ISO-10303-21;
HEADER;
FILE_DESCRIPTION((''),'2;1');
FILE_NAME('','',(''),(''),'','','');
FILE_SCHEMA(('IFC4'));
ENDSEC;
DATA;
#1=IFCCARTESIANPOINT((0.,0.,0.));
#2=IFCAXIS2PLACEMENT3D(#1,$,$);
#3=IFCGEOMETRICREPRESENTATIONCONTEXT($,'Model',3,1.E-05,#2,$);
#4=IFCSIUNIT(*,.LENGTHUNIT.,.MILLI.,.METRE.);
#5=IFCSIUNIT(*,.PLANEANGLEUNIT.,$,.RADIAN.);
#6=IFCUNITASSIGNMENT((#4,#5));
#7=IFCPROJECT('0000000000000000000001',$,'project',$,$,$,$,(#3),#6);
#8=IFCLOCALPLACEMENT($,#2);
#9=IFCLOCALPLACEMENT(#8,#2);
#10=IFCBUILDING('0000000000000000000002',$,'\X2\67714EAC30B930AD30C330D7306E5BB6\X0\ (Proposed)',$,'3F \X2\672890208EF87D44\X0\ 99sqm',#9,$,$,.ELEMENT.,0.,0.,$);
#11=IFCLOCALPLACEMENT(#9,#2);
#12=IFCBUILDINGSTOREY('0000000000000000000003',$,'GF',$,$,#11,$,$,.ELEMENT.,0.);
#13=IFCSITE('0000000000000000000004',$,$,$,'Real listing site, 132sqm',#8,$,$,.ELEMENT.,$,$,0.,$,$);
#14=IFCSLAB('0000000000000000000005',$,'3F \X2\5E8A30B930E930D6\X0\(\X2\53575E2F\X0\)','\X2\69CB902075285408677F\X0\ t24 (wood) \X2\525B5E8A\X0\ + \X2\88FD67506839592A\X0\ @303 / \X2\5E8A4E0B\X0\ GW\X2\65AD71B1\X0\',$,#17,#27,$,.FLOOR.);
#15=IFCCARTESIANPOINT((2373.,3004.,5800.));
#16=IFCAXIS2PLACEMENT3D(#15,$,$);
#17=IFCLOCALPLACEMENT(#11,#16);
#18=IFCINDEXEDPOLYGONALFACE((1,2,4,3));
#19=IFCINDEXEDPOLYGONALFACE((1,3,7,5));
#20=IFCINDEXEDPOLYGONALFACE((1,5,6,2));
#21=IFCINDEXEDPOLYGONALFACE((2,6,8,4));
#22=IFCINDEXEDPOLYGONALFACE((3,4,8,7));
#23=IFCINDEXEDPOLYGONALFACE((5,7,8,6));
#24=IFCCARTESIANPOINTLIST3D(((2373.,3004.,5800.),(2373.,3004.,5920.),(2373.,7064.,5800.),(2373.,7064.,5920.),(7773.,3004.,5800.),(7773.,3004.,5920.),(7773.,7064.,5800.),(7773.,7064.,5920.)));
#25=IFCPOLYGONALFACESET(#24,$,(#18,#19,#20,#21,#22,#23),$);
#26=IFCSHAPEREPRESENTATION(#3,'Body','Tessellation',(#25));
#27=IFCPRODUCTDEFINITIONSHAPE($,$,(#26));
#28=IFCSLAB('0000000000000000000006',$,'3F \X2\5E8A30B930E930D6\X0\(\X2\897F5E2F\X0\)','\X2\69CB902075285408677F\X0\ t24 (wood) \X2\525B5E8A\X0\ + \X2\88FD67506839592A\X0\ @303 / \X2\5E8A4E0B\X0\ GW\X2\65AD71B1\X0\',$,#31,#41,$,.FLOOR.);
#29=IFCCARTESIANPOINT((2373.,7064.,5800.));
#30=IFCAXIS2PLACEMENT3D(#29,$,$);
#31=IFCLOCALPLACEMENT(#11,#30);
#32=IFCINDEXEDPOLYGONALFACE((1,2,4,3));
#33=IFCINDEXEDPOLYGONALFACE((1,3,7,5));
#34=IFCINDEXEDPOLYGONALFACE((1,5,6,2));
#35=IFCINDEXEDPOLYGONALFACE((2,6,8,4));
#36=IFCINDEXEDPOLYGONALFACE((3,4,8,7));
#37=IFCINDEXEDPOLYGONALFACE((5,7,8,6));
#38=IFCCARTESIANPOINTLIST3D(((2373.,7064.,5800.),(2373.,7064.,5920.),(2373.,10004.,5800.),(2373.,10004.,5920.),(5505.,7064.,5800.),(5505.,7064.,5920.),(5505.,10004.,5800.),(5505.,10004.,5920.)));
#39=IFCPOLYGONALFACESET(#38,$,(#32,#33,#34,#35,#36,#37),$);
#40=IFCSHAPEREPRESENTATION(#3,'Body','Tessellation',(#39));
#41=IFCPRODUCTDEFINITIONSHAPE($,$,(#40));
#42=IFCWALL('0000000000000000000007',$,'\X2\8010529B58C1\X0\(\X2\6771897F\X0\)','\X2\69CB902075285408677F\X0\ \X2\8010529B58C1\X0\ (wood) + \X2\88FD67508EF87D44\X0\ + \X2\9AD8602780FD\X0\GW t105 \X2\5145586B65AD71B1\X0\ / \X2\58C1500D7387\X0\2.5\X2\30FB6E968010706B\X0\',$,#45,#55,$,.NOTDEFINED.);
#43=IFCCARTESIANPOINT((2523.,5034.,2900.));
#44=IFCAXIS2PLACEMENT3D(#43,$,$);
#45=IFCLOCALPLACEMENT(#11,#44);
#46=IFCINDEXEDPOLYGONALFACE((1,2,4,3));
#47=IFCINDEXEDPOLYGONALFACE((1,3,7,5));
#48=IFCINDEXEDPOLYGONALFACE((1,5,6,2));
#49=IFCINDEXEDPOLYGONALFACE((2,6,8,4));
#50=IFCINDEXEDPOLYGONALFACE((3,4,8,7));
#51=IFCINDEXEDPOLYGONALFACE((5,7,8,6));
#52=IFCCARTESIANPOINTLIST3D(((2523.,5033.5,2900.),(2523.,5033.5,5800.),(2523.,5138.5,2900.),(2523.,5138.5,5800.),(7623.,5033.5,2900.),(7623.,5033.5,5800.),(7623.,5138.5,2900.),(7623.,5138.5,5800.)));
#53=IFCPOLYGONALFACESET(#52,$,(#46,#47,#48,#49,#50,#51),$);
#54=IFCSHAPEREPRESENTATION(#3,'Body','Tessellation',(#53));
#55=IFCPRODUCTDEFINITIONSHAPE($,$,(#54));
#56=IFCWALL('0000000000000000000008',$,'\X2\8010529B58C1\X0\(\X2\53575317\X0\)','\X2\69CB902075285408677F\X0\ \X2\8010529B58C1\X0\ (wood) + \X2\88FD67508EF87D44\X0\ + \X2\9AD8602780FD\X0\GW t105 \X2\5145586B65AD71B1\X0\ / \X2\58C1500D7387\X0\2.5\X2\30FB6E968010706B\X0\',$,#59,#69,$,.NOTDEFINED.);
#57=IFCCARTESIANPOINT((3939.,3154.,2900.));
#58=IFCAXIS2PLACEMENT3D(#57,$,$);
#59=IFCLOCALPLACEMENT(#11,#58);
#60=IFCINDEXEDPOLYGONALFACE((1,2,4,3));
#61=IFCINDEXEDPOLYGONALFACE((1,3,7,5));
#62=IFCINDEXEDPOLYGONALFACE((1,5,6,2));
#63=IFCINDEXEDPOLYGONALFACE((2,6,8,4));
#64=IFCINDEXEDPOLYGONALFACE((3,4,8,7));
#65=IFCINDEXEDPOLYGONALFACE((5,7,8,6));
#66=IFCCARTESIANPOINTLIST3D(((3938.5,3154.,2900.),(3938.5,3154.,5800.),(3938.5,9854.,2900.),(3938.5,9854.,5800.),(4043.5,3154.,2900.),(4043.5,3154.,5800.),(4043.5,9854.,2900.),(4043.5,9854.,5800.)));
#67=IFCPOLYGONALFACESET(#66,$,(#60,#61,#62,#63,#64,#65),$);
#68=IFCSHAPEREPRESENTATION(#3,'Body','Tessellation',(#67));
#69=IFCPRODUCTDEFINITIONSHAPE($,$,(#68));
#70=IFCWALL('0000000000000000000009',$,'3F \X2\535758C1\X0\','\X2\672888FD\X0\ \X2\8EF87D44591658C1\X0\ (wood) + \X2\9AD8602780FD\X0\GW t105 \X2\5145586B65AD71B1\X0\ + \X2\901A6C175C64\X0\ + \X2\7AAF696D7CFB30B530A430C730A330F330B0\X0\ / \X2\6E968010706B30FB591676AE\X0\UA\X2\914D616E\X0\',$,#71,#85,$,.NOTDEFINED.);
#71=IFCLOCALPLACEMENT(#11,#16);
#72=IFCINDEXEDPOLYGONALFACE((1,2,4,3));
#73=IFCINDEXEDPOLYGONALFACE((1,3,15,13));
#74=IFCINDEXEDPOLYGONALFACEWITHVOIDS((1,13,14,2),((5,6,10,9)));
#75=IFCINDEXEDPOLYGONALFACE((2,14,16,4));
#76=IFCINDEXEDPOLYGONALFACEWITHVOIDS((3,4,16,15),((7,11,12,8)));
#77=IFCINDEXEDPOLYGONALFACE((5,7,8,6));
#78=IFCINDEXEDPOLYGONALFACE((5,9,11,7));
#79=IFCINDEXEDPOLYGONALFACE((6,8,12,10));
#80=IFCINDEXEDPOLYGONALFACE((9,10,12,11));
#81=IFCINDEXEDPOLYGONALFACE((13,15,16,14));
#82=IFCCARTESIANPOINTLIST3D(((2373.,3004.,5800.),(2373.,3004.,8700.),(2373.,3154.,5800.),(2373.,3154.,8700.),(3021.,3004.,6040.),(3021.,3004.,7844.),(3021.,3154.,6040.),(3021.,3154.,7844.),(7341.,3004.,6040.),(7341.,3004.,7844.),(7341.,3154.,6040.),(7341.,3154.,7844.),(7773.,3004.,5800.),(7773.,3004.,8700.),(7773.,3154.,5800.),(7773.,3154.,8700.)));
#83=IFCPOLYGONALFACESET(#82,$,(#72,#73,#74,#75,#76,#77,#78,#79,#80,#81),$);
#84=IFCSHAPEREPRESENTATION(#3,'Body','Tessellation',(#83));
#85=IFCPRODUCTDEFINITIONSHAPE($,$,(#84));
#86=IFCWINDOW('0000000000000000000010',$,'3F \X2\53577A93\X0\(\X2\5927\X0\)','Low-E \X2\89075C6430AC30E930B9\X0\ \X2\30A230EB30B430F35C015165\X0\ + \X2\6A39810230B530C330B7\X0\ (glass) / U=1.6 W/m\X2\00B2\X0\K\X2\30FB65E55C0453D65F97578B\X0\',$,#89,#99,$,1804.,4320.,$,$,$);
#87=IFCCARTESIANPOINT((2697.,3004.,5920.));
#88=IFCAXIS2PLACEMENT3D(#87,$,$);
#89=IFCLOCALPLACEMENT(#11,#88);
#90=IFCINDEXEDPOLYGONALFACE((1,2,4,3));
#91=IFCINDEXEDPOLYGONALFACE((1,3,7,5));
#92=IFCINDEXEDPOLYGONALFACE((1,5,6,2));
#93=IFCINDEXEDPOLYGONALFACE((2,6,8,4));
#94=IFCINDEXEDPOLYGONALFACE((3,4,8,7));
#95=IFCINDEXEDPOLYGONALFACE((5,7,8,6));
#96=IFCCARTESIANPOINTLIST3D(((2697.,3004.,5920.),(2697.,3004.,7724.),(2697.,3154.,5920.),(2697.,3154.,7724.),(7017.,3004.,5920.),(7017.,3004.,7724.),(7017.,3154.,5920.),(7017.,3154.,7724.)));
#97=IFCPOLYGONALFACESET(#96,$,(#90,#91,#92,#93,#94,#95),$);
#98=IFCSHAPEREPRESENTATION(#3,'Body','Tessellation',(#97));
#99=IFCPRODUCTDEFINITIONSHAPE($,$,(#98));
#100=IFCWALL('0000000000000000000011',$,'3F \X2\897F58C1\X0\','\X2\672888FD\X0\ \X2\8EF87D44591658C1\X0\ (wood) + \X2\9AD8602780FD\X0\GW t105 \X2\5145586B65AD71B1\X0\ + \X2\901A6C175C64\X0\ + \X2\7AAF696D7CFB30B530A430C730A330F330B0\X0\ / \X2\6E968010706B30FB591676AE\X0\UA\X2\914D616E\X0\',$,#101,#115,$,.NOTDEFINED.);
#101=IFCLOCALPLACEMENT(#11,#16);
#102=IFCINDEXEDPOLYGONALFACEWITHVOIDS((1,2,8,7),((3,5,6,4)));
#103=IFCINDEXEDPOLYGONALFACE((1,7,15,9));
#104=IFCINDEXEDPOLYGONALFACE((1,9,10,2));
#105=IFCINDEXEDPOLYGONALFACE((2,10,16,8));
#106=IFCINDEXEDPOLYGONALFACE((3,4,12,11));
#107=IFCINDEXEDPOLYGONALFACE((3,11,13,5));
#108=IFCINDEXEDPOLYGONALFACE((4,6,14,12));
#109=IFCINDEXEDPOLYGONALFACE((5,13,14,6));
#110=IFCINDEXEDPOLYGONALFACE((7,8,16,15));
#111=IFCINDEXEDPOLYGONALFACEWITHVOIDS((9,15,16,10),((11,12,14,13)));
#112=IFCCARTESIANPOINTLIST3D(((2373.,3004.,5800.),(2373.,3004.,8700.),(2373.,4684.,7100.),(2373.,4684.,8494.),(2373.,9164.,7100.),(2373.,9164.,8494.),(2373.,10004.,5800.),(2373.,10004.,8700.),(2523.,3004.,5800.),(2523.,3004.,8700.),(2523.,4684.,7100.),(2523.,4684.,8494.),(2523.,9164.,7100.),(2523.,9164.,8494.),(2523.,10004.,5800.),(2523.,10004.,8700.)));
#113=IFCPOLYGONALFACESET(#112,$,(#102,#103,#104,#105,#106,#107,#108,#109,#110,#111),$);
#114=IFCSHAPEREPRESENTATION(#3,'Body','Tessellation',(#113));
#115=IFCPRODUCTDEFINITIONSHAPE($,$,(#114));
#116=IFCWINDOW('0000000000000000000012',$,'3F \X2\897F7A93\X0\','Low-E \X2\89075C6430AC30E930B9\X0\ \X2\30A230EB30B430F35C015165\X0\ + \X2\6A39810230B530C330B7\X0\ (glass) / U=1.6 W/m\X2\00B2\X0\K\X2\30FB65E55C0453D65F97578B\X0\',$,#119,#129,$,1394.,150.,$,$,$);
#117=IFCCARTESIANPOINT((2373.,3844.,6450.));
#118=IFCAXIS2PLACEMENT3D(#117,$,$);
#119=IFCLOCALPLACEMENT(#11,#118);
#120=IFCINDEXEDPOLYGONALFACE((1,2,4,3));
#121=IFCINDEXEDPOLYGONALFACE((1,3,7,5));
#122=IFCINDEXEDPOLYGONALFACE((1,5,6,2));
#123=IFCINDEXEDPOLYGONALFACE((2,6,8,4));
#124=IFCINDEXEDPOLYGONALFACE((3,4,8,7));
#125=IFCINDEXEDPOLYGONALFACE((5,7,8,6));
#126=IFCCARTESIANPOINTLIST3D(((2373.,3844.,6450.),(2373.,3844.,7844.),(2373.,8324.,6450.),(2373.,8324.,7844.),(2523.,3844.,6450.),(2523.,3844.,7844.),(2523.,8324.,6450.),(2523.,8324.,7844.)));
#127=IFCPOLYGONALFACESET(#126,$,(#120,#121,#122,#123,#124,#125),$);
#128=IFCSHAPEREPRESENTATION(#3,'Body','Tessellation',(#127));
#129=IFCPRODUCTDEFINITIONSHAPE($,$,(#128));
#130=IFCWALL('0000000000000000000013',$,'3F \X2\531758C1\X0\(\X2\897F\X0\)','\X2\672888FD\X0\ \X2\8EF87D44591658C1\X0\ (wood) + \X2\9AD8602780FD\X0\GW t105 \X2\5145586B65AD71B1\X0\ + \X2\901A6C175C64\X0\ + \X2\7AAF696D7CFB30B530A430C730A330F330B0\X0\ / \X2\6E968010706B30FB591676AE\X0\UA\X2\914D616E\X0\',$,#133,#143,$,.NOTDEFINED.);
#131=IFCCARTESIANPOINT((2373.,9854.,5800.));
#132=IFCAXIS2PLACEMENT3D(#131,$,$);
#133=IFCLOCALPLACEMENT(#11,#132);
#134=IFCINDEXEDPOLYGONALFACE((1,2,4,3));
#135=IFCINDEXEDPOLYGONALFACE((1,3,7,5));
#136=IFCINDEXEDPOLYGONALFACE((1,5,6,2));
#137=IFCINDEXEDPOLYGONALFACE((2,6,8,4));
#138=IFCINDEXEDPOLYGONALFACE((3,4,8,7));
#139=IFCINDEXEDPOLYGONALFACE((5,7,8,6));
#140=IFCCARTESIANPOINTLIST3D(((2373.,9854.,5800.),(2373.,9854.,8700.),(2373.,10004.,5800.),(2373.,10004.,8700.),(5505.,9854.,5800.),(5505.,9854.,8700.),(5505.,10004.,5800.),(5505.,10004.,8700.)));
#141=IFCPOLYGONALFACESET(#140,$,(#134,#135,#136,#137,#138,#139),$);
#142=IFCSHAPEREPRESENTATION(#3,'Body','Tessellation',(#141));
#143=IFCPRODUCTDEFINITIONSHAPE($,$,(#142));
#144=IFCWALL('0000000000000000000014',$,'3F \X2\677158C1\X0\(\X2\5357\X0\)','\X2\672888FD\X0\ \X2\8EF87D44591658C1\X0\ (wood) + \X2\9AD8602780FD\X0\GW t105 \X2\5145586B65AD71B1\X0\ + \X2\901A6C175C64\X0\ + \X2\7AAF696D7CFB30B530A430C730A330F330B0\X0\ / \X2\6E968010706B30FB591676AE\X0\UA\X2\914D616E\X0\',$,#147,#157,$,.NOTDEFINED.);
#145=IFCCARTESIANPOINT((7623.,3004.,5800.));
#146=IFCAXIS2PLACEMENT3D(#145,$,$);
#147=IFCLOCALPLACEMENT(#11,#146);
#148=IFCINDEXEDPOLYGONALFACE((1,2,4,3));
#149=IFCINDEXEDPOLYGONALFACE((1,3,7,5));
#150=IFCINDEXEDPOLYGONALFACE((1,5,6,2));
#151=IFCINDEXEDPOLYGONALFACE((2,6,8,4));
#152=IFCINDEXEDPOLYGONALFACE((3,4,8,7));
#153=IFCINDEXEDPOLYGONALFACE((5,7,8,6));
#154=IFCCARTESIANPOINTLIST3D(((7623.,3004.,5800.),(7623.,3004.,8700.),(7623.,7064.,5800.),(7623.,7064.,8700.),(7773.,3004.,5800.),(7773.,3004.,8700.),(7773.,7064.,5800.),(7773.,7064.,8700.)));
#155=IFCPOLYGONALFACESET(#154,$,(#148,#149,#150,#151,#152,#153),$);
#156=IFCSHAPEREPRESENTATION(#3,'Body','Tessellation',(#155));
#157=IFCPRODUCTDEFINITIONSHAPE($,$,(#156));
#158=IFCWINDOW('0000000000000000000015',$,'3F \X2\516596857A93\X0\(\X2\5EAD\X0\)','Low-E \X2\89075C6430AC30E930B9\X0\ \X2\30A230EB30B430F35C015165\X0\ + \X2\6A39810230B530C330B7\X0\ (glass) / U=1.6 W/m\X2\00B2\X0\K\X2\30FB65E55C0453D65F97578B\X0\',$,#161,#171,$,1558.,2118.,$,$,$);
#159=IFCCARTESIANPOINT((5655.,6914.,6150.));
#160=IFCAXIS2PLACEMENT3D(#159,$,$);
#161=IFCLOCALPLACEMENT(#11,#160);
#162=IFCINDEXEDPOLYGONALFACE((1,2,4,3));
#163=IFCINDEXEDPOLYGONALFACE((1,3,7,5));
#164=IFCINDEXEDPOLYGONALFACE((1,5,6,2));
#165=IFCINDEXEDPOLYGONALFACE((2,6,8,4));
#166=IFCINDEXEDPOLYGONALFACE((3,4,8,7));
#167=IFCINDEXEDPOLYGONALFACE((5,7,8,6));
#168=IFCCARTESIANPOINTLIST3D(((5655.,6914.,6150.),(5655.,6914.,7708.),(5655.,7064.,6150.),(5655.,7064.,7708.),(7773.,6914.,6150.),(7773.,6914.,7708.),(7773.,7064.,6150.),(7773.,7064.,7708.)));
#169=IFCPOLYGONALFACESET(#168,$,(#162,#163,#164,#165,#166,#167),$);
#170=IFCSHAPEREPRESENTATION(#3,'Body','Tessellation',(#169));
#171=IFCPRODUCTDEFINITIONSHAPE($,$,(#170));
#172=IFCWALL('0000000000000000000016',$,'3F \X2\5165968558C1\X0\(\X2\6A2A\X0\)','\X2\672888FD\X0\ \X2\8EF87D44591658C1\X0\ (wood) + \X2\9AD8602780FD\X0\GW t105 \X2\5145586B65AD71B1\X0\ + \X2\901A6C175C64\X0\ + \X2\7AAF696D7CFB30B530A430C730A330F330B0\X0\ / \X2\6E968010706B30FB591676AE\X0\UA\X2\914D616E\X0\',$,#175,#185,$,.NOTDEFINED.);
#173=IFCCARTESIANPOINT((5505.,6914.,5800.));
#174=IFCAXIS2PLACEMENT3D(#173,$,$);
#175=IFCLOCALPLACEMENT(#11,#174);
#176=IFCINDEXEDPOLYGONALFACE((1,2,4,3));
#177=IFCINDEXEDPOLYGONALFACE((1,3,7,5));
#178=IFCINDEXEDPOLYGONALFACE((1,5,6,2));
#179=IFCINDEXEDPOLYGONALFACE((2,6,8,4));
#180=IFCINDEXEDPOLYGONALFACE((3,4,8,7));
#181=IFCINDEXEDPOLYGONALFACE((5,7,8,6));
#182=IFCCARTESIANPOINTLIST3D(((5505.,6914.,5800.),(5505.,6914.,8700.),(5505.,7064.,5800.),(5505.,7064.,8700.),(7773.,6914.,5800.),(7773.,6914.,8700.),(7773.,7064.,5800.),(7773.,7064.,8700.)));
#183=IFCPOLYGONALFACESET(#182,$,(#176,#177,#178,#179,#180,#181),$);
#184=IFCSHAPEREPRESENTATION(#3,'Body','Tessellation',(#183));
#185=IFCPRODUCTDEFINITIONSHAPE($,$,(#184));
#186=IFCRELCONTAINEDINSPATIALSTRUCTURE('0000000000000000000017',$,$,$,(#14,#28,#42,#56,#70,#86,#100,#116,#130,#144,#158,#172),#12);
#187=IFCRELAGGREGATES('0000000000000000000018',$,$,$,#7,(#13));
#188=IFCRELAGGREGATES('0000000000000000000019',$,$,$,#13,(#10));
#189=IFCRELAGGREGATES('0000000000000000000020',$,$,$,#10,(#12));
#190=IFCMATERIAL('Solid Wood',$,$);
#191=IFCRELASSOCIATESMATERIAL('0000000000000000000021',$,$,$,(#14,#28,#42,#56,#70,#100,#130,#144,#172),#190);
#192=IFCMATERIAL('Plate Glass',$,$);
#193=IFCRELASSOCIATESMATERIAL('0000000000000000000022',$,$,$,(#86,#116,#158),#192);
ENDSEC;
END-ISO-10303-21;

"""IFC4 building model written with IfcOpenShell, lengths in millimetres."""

from ifc_helpers import new_model, si_unit, frame, frame_2d, origin, place, context, project, spatial, rectangle, extrude, material, element, fill, save


model = new_model("IFC4")

# Units and contexts
model_context = context("Model", 3, precision=1e-05, world=origin())
ifc_project = project(units=[si_unit("LENGTHUNIT", "METRE", prefix="MILLI"), si_unit("PLANEANGLEUNIT", "RADIAN")], contexts=[model_context])

# Site, building, storey
site_placement = place(None, origin())
site = spatial("IfcSite", under=ifc_project, at=site_placement, ObjectType="Real listing site, 132sqm", CompositionType="ELEMENT", RefElevation=0.0)
building_placement = place(site_placement, origin())
building = spatial("IfcBuilding", under=site, at=building_placement, Name="東京スキップの家 (Proposed)", ObjectType="3F 木造軸組 99sqm", CompositionType="ELEMENT", ElevationOfRefHeight=0.0, ElevationOfTerrain=0.0)
storey_placement = place(building_placement, origin())
storey = spatial("IfcBuildingStorey", under=building, at=storey_placement, Name="GF", CompositionType="ELEMENT", Elevation=0.0)

# Slabs
ifc_material_1 = material(Name="Solid Wood")
slab_1_placement = place(storey_placement, frame((2373.0, 3004.0, 5800.0)))
element("IfcSlab", 1, at=slab_1_placement, inside=storey, material=ifc_material_1, Name="3F 床スラブ(南帯)", Description="構造用合板 t24 (wood) 剛床 + 製材根太 @303 / 床下 GW断熱", PredefinedType="FLOOR", context=model_context, shape_type="SweptSolid", body=[
    extrude(rectangle(XDim=5400.0, YDim=4060.0, at=frame_2d((2700.0, 2030.0))), frame((2373.0, 3004.0, 5800.0)), (0.0, 0.0, 1.0), 120.0),
])
slab_2_placement = place(storey_placement, frame((2373.0, 7064.0, 5800.0)))
element("IfcSlab", 2, at=slab_2_placement, inside=storey, material=ifc_material_1, Name="3F 床スラブ(西帯)", Description="構造用合板 t24 (wood) 剛床 + 製材根太 @303 / 床下 GW断熱", PredefinedType="FLOOR", context=model_context, shape_type="SweptSolid", body=[
    extrude(rectangle(XDim=3132.0, YDim=2940.0, at=frame_2d((1566.0, 1470.0))), frame((2373.0, 7064.0, 5800.0)), (0.0, 0.0, 1.0), 120.0),
])

# Walls
wall_1_placement = place(storey_placement, frame((2523.0, 5034.0, 2900.0)))
element("IfcWall", 3, at=wall_1_placement, inside=storey, material=ifc_material_1, Name="耐力壁(東西)", Description="構造用合板 耐力壁 (wood) + 製材軸組 + 高性能GW t105 充填断熱 / 壁倍率2.5・準耐火", PredefinedType="NOTDEFINED", context=model_context, shape_type="SweptSolid", body=[
    extrude(rectangle(XDim=5100.0, YDim=105.0, at=frame_2d((2550.0, 52.0))), frame((2523.0, 5034.0, 2900.0)), (0.0, 0.0, 1.0), 2900.0),
])
wall_2_placement = place(storey_placement, frame((3939.0, 3154.0, 2900.0)))
element("IfcWall", 4, at=wall_2_placement, inside=storey, material=ifc_material_1, Name="耐力壁(南北)", Description="構造用合板 耐力壁 (wood) + 製材軸組 + 高性能GW t105 充填断熱 / 壁倍率2.5・準耐火", PredefinedType="NOTDEFINED", context=model_context, shape_type="SweptSolid", body=[
    extrude(rectangle(XDim=105.0, YDim=6700.0, at=frame_2d((52.0, 3350.0))), frame((3939.0, 3154.0, 2900.0)), (0.0, 0.0, 1.0), 2900.0),
])

# Walls, openings, windows
wall_3_placement = place(storey_placement, frame((2373.0, 3004.0, 5800.0)))
wall_3 = element("IfcWall", 5, at=wall_3_placement, inside=storey, material=ifc_material_1, Name="3F 南壁", Description="木製 軸組外壁 (wood) + 高性能GW t105 充填断熱 + 通気層 + 窯業系サイディング / 準耐火・外皮UA配慮", PredefinedType="NOTDEFINED", context=model_context, shape_type="SweptSolid", body=[
    extrude(rectangle(XDim=5400.0, YDim=150.0, at=frame_2d((2700.0, 75.0))), frame((2373.0, 3004.0, 5800.0)), (0.0, 0.0, 1.0), 2900.0),
])
opening_1_placement = place(storey_placement, frame((2697.0, 3004.0, 5920.0)))
opening_1 = element("IfcOpeningElement", 6, at=opening_1_placement, cuts=wall_3, PredefinedType="NOTDEFINED", context=model_context, shape_type="SweptSolid", body=[
    extrude(rectangle(XDim=4320.0, YDim=150.0, at=frame_2d((2160.0, 75.0))), frame((2697.0, 3004.0, 5920.0)), (0.0, 0.0, 1.0), 1804.0),
])
ifc_material_2 = material(Name="Plate Glass")
window_1_placement = place(storey_placement, frame((2697.0, 3004.0, 5920.0)))
window_1 = element("IfcWindow", 7, at=window_1_placement, inside=storey, material=ifc_material_2, Name="3F 南窓(大)", Description="Low-E 複層ガラス アルゴン封入 + 樹脂サッシ (glass) / U=1.6 W/m²K・日射取得型", OverallHeight=1804.0, OverallWidth=4320.0, context=model_context, shape_type="SweptSolid", body=[
    extrude(rectangle(XDim=4320.0, YDim=150.0, at=frame_2d((2160.0, 75.0))), frame((2697.0, 3004.0, 5920.0)), (0.0, 0.0, 1.0), 1804.0),
])
fill(opening_1, window_1)
wall_4_placement = place(storey_placement, frame((2373.0, 3004.0, 5800.0)))
wall_4 = element("IfcWall", 8, at=wall_4_placement, inside=storey, material=ifc_material_1, Name="3F 西壁", Description="木製 軸組外壁 (wood) + 高性能GW t105 充填断熱 + 通気層 + 窯業系サイディング / 準耐火・外皮UA配慮", PredefinedType="NOTDEFINED", context=model_context, shape_type="SweptSolid", body=[
    extrude(rectangle(XDim=150.0, YDim=7000.0, at=frame_2d((75.0, 3500.0))), frame((2373.0, 3004.0, 5800.0)), (0.0, 0.0, 1.0), 2900.0),
])
opening_2_placement = place(storey_placement, frame((2373.0, 3844.0, 6450.0)))
opening_2 = element("IfcOpeningElement", 9, at=opening_2_placement, cuts=wall_4, PredefinedType="NOTDEFINED", context=model_context, shape_type="SweptSolid", body=[
    extrude(rectangle(XDim=150.0, YDim=4480.0, at=frame_2d((75.0, 2240.0))), frame((2373.0, 3844.0, 6450.0)), (0.0, 0.0, 1.0), 1394.0),
])
window_2_placement = place(storey_placement, frame((2373.0, 3844.0, 6450.0)))
window_2 = element("IfcWindow", 10, at=window_2_placement, inside=storey, material=ifc_material_2, Name="3F 西窓", Description="Low-E 複層ガラス アルゴン封入 + 樹脂サッシ (glass) / U=1.6 W/m²K・日射取得型", OverallHeight=1394.0, OverallWidth=150.0, context=model_context, shape_type="SweptSolid", body=[
    extrude(rectangle(XDim=150.0, YDim=4480.0, at=frame_2d((75.0, 2240.0))), frame((2373.0, 3844.0, 6450.0)), (0.0, 0.0, 1.0), 1394.0),
])
fill(opening_2, window_2)

# Wall
wall_5_placement = place(storey_placement, frame((2373.0, 9854.0, 5800.0)))
element("IfcWall", 11, at=wall_5_placement, inside=storey, material=ifc_material_1, Name="3F 北壁(西)", Description="木製 軸組外壁 (wood) + 高性能GW t105 充填断熱 + 通気層 + 窯業系サイディング / 準耐火・外皮UA配慮", PredefinedType="NOTDEFINED", context=model_context, shape_type="SweptSolid", body=[
    extrude(rectangle(XDim=3132.0, YDim=150.0, at=frame_2d((1566.0, 75.0))), frame((2373.0, 9854.0, 5800.0)), (0.0, 0.0, 1.0), 2900.0),
])

# Wall, opening, window
wall_6_placement = place(storey_placement, frame((7623.0, 3004.0, 5800.0)))
wall_6 = element("IfcWall", 12, at=wall_6_placement, inside=storey, material=ifc_material_1, Name="3F 東壁(南)", Description="木製 軸組外壁 (wood) + 高性能GW t105 充填断熱 + 通気層 + 窯業系サイディング / 準耐火・外皮UA配慮", PredefinedType="NOTDEFINED", context=model_context, shape_type="SweptSolid", body=[
    extrude(rectangle(XDim=150.0, YDim=4060.0, at=frame_2d((75.0, 2030.0))), frame((7623.0, 3004.0, 5800.0)), (0.0, 0.0, 1.0), 2900.0),
])
opening_3_placement = place(storey_placement, frame((5655.0, 6914.0, 6150.0)))
opening_3 = element("IfcOpeningElement", 13, at=opening_3_placement, cuts=wall_6, PredefinedType="NOTDEFINED", context=model_context, shape_type="SweptSolid", body=[
    extrude(rectangle(XDim=2118.0, YDim=150.0, at=frame_2d((1059.0, 75.0))), frame((5655.0, 6914.0, 6150.0)), (0.0, 0.0, 1.0), 1558.0),
])
window_3_placement = place(storey_placement, frame((5655.0, 6914.0, 6150.0)))
window_3 = element("IfcWindow", 14, at=window_3_placement, inside=storey, material=ifc_material_2, Name="3F 入隅窓(庭)", Description="Low-E 複層ガラス アルゴン封入 + 樹脂サッシ (glass) / U=1.6 W/m²K・日射取得型", OverallHeight=1558.0, OverallWidth=2118.0, context=model_context, shape_type="SweptSolid", body=[
    extrude(rectangle(XDim=2118.0, YDim=150.0, at=frame_2d((1059.0, 75.0))), frame((5655.0, 6914.0, 6150.0)), (0.0, 0.0, 1.0), 1558.0),
])
fill(opening_3, window_3)

# Wall
wall_7_placement = place(storey_placement, frame((5505.0, 6914.0, 5800.0)))
element("IfcWall", 15, at=wall_7_placement, inside=storey, material=ifc_material_1, Name="3F 入隅壁(横)", Description="木製 軸組外壁 (wood) + 高性能GW t105 充填断熱 + 通気層 + 窯業系サイディング / 準耐火・外皮UA配慮", PredefinedType="NOTDEFINED", context=model_context, shape_type="SweptSolid", body=[
    extrude(rectangle(XDim=2268.0, YDim=150.0, at=frame_2d((1134.0, 75.0))), frame((5505.0, 6914.0, 5800.0)), (0.0, 0.0, 1.0), 2900.0),
])

save(model, "model.ifc")
